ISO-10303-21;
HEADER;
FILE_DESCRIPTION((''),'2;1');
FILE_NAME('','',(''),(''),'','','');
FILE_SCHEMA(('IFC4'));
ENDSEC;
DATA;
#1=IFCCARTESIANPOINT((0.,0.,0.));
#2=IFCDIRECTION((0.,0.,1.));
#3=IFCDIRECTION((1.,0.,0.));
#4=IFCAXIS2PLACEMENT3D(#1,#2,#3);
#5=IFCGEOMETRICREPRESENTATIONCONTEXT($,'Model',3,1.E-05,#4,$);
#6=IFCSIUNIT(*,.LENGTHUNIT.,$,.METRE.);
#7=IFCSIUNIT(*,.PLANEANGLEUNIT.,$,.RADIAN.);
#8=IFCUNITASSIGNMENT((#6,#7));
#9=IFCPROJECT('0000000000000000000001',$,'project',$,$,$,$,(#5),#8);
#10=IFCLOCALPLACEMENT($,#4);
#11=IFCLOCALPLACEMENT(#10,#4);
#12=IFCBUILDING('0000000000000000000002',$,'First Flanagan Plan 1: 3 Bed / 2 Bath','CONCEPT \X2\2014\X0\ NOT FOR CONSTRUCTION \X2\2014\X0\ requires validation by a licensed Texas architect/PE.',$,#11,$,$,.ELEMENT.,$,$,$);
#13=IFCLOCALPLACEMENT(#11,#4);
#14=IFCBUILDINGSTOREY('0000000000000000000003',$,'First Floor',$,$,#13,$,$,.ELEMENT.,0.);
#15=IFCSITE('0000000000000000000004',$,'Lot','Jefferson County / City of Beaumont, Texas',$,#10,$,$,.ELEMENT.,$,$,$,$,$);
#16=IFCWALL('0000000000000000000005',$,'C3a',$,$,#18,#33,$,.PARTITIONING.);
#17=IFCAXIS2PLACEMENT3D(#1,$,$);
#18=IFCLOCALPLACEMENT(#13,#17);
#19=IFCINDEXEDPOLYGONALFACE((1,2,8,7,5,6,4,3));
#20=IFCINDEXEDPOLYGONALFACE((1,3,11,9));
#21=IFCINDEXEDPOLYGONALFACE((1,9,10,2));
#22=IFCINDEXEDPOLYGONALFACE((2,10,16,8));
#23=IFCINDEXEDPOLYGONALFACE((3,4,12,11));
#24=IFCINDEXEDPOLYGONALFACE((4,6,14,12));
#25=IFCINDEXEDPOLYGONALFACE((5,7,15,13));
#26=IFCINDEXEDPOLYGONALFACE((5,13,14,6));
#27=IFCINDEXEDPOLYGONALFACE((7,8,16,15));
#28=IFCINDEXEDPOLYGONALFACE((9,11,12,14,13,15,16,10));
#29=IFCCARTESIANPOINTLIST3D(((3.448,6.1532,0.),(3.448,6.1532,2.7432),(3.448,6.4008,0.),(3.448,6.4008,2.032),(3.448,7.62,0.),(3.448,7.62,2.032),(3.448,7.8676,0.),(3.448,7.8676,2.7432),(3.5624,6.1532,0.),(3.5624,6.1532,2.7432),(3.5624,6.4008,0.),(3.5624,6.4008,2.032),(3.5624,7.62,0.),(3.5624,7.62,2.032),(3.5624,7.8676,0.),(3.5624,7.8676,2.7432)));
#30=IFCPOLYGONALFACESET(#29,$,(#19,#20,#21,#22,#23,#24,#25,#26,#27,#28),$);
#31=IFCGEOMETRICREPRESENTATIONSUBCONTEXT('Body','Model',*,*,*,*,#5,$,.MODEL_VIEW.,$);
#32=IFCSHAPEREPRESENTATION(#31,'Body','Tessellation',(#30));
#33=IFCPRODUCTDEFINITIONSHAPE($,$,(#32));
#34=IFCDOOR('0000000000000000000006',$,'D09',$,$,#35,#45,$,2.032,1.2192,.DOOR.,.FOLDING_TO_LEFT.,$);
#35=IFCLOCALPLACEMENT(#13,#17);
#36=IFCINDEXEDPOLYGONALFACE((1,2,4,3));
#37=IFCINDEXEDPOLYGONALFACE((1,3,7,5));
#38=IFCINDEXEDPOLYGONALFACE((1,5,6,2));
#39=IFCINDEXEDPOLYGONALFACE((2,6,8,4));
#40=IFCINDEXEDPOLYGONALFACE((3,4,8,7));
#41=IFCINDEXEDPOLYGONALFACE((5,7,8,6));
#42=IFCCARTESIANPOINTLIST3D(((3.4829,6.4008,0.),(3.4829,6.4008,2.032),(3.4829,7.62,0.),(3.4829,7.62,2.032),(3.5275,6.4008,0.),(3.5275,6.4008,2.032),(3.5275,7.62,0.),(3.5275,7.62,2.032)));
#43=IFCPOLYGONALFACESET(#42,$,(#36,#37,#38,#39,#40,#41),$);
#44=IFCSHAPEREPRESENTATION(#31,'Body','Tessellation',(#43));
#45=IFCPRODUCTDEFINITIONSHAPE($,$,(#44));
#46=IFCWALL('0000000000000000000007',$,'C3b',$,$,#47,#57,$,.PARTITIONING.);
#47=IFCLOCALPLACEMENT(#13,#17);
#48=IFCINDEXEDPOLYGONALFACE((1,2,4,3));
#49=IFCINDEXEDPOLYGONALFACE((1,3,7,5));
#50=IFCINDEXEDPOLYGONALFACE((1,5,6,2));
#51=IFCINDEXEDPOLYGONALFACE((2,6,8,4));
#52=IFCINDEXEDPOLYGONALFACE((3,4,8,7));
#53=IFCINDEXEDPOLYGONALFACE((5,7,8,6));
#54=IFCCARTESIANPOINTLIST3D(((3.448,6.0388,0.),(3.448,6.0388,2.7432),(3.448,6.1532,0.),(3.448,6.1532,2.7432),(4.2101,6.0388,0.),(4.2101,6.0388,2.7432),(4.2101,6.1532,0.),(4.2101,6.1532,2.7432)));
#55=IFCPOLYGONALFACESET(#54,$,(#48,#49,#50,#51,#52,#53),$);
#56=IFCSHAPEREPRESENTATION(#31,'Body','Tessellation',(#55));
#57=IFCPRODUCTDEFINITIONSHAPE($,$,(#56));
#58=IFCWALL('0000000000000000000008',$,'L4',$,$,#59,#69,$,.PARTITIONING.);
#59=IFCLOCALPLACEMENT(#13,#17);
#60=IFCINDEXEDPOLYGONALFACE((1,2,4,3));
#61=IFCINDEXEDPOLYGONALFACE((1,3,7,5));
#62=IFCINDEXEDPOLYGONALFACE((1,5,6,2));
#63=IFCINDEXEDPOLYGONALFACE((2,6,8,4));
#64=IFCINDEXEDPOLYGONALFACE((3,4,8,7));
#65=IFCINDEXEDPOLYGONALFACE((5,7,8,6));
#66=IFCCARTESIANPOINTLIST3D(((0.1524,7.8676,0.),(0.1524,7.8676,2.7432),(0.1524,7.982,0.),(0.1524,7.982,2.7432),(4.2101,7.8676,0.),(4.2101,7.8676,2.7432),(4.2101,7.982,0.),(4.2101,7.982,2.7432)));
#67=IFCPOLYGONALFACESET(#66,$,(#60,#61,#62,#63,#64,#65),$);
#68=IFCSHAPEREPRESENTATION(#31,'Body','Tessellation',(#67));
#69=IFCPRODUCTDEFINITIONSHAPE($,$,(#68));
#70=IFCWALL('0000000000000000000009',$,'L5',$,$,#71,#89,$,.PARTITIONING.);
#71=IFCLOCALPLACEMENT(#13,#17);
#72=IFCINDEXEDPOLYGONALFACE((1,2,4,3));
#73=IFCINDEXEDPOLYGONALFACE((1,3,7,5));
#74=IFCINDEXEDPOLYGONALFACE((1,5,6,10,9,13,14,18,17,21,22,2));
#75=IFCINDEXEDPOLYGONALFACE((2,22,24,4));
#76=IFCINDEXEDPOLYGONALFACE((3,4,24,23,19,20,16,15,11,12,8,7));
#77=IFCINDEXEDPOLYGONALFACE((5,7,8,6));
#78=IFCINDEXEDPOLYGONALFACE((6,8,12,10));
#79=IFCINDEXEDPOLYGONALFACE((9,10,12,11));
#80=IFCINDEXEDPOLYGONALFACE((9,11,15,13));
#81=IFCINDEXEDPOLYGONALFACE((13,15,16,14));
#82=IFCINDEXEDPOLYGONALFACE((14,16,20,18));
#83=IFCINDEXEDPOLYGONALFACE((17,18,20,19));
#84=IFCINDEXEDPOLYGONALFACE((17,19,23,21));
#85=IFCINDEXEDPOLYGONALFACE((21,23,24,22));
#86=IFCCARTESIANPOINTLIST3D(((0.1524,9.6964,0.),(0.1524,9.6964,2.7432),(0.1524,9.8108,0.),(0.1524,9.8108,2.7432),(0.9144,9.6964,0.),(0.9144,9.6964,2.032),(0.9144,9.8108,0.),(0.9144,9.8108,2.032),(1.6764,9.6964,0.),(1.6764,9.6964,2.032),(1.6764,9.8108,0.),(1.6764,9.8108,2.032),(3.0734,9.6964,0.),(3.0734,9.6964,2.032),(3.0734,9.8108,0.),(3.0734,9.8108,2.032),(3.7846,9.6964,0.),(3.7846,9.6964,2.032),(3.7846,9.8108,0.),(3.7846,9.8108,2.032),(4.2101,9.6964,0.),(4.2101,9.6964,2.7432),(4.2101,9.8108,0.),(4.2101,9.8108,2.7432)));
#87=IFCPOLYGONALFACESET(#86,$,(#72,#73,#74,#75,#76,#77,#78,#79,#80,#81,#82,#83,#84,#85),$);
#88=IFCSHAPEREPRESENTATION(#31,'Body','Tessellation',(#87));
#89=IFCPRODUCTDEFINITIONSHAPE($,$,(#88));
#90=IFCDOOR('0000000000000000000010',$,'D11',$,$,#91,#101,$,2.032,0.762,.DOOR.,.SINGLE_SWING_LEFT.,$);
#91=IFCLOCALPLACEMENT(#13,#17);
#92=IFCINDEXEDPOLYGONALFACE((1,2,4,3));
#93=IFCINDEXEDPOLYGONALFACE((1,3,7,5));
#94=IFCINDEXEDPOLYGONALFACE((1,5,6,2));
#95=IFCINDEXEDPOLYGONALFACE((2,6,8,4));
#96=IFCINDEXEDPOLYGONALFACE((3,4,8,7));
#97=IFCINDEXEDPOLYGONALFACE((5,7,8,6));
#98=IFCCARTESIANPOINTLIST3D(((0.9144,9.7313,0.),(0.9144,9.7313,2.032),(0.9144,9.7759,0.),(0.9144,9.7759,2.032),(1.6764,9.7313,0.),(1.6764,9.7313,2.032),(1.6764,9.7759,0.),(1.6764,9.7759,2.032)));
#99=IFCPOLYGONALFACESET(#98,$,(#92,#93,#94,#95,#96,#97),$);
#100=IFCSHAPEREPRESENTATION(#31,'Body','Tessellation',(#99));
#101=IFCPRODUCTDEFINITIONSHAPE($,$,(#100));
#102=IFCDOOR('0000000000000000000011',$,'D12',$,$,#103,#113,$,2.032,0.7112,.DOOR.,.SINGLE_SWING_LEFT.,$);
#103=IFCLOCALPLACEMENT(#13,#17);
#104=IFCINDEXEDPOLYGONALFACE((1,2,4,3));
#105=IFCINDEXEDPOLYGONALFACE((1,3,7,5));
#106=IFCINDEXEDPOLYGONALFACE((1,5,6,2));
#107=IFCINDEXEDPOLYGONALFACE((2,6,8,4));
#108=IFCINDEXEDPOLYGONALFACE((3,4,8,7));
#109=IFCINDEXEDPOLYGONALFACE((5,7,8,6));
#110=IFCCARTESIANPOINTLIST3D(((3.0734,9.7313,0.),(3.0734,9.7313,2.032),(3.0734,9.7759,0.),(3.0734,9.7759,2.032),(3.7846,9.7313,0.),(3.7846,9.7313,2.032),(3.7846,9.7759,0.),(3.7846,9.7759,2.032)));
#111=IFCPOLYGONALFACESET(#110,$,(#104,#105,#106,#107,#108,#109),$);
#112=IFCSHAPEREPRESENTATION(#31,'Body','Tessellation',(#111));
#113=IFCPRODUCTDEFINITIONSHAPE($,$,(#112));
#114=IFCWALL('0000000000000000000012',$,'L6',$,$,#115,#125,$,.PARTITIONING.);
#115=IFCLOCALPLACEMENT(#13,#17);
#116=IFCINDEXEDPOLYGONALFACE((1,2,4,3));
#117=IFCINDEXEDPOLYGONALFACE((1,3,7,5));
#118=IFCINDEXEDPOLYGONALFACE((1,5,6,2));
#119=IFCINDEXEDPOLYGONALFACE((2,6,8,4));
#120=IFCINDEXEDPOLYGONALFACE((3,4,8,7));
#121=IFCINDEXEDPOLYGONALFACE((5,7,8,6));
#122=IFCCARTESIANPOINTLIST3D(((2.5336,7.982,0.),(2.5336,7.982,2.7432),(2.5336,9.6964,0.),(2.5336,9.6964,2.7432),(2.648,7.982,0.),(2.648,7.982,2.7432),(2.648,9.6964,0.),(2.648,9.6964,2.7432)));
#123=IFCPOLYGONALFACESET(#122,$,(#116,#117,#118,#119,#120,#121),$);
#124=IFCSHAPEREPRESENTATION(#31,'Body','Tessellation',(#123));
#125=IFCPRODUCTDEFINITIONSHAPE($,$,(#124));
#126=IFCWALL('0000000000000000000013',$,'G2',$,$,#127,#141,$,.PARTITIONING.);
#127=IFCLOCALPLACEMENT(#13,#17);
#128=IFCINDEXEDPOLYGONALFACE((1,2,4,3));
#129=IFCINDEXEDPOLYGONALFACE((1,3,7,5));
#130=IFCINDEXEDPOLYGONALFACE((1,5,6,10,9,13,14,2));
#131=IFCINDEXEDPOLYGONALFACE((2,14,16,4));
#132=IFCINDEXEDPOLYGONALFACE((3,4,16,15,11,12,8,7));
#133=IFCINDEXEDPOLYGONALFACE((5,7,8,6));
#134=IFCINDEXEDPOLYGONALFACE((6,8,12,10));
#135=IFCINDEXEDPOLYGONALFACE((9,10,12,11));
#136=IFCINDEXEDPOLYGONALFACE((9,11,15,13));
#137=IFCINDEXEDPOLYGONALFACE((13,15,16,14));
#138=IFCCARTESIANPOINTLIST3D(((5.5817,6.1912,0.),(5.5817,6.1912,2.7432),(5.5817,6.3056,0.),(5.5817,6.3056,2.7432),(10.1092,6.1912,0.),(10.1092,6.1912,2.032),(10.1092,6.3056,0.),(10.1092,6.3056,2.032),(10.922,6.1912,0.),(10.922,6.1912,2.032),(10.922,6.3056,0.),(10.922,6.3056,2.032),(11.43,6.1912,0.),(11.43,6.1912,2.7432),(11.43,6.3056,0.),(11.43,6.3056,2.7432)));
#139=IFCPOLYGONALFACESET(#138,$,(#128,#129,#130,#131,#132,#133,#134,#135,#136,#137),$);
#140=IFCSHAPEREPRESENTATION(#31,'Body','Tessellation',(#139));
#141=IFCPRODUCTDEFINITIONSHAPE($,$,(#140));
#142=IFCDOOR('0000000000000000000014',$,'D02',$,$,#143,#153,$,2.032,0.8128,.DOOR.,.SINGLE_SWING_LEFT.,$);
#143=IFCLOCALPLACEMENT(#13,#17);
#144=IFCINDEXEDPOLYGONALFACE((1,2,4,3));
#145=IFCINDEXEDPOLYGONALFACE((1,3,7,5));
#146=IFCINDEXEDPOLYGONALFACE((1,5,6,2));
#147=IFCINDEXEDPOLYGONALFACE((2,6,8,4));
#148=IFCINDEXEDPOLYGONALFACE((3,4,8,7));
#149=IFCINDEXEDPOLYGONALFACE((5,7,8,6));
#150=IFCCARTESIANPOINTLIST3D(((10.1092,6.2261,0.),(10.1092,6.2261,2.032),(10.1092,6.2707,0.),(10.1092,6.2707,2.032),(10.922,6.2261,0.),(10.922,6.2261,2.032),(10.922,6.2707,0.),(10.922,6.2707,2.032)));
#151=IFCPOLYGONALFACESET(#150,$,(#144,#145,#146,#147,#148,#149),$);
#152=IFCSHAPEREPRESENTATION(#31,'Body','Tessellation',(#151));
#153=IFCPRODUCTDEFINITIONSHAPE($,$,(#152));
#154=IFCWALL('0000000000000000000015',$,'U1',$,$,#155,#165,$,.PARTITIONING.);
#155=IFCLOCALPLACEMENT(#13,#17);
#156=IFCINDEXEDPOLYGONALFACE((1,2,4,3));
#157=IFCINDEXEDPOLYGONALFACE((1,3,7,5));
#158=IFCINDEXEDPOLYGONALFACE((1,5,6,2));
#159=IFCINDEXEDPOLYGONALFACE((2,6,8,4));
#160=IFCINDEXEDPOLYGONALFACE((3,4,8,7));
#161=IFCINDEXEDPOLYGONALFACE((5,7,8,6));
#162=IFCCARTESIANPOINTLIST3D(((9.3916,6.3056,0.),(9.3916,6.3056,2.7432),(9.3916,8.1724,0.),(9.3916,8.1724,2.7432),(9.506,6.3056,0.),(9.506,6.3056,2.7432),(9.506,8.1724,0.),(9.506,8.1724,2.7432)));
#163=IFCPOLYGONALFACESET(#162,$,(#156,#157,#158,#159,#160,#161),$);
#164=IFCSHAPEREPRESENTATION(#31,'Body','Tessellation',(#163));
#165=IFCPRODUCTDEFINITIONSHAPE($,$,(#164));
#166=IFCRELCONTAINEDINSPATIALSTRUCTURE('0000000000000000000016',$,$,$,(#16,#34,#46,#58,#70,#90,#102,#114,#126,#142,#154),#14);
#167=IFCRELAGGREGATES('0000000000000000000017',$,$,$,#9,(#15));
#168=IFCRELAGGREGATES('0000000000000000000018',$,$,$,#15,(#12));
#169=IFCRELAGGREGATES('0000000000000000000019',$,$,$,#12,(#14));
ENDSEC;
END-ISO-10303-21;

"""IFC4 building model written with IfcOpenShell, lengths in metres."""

from ifc_helpers import new_model, si_unit, frame, frame_2d, origin_with_axes, place, context, subcontext, project, spatial, rectangle, extrude, element, fill, save


model = new_model("IFC4")

# Units and contexts
model_context = context("Model", 3, precision=1e-05, world=origin_with_axes())
body_context = subcontext(model_context, "Body", "Model", "MODEL_VIEW")
ifc_project = project(units=[si_unit("LENGTHUNIT", "METRE"), si_unit("PLANEANGLEUNIT", "RADIAN")], contexts=[model_context])

# Site, building, storey
site_placement = place(None, origin_with_axes())
site = spatial("IfcSite", under=ifc_project, at=site_placement, Name="Lot", Description="Jefferson County / City of Beaumont, Texas", CompositionType="ELEMENT")
building_placement = place(site_placement, origin_with_axes())
building = spatial("IfcBuilding", under=site, at=building_placement, Name="First Flanagan Plan 1: 3 Bed / 2 Bath", Description="CONCEPT — NOT FOR CONSTRUCTION — requires validation by a licensed Texas architect/PE.", CompositionType="ELEMENT")
storey_placement = place(building_placement, origin_with_axes())
storey = spatial("IfcBuildingStorey", under=building, at=storey_placement, Name="First Floor", CompositionType="ELEMENT", Elevation=0.0)

# Wall, opening, door
wall_1_placement = place(storey_placement, frame((3.5052, 6.1532, 0.0), z_axis=(0.0, 0.0, 1.0), x_axis=(0.0, 1.0, 0.0)))
wall_1 = element("IfcWall", 1, at=wall_1_placement, inside=storey, Name="C3a", PredefinedType="PARTITIONING", context=body_context, shape_type="SweptSolid", body=[
    extrude(rectangle(XDim=1.7145, YDim=0.1143, at=frame_2d((0.8573, 0.0), x_axis=(1.0, 0.0))), origin_with_axes(), (0.0, 0.0, 1.0), 2.7432),
])
opening_1_placement = place(wall_1_placement, frame((0.2477, 0.0, 0.0), z_axis=(0.0, 0.0, 1.0), x_axis=(1.0, 0.0, 0.0)))
opening_1 = element("IfcOpeningElement", 2, at=opening_1_placement, cuts=wall_1, PredefinedType="OPENING", context=body_context, shape_type="SweptSolid", body=[
    extrude(rectangle(XDim=1.2192, YDim=0.1448, at=frame_2d((0.6096, 0.0), x_axis=(1.0, 0.0))), origin_with_axes(), (0.0, 0.0, 1.0), 2.032),
])
door_1_placement = place(opening_1_placement, origin_with_axes())
door_1 = element("IfcDoor", 3, at=door_1_placement, inside=storey, Name="D09", OperationType="FOLDING_TO_LEFT", OverallHeight=2.032, OverallWidth=1.2192, PredefinedType="DOOR", context=body_context, shape_type="SweptSolid", body=[
    extrude(rectangle(XDim=1.2192, YDim=0.0445, at=frame_2d((0.6096, 0.0), x_axis=(1.0, 0.0))), origin_with_axes(), (0.0, 0.0, 1.0), 2.032),
])
fill(opening_1, door_1)

# Walls
wall_2_placement = place(storey_placement, frame((3.4481, 6.096, 0.0), z_axis=(0.0, 0.0, 1.0), x_axis=(1.0, 0.0, 0.0)))
element("IfcWall", 4, at=wall_2_placement, inside=storey, Name="C3b", PredefinedType="PARTITIONING", context=body_context, shape_type="SweptSolid", body=[
    extrude(rectangle(XDim=0.762, YDim=0.1143, at=frame_2d((0.381, 0.0), x_axis=(1.0, 0.0))), origin_with_axes(), (0.0, 0.0, 1.0), 2.7432),
])
wall_3_placement = place(storey_placement, frame((0.1524, 7.9248, 0.0), z_axis=(0.0, 0.0, 1.0), x_axis=(1.0, 0.0, 0.0)))
element("IfcWall", 5, at=wall_3_placement, inside=storey, Name="L4", PredefinedType="PARTITIONING", context=body_context, shape_type="SweptSolid", body=[
    extrude(rectangle(XDim=4.0577, YDim=0.1143, at=frame_2d((2.0288, 0.0), x_axis=(1.0, 0.0))), origin_with_axes(), (0.0, 0.0, 1.0), 2.7432),
])

# Wall, openings, doors
wall_4_placement = place(storey_placement, frame((0.1524, 9.7536, 0.0), z_axis=(0.0, 0.0, 1.0), x_axis=(1.0, 0.0, 0.0)))
wall_4 = element("IfcWall", 6, at=wall_4_placement, inside=storey, Name="L5", PredefinedType="PARTITIONING", context=body_context, shape_type="SweptSolid", body=[
    extrude(rectangle(XDim=4.0577, YDim=0.1143, at=frame_2d((2.0288, 0.0), x_axis=(1.0, 0.0))), origin_with_axes(), (0.0, 0.0, 1.0), 2.7432),
])
opening_2_placement = place(wall_4_placement, frame((0.762, 0.0, 0.0), z_axis=(0.0, 0.0, 1.0), x_axis=(1.0, 0.0, 0.0)))
opening_2 = element("IfcOpeningElement", 7, at=opening_2_placement, cuts=wall_4, PredefinedType="OPENING", context=body_context, shape_type="SweptSolid", body=[
    extrude(rectangle(XDim=0.762, YDim=0.1448, at=frame_2d((0.381, 0.0), x_axis=(1.0, 0.0))), origin_with_axes(), (0.0, 0.0, 1.0), 2.032),
])
opening_3_placement = place(wall_4_placement, frame((2.921, 0.0, 0.0), z_axis=(0.0, 0.0, 1.0), x_axis=(1.0, 0.0, 0.0)))
opening_3 = element("IfcOpeningElement", 8, at=opening_3_placement, cuts=wall_4, PredefinedType="OPENING", context=body_context, shape_type="SweptSolid", body=[
    extrude(rectangle(XDim=0.7112, YDim=0.1448, at=frame_2d((0.3556, 0.0), x_axis=(1.0, 0.0))), origin_with_axes(), (0.0, 0.0, 1.0), 2.032),
])
door_2_placement = place(opening_2_placement, origin_with_axes())
door_2 = element("IfcDoor", 9, at=door_2_placement, inside=storey, Name="D11", OperationType="SINGLE_SWING_LEFT", OverallHeight=2.032, OverallWidth=0.762, PredefinedType="DOOR", context=body_context, shape_type="SweptSolid", body=[
    extrude(rectangle(XDim=0.762, YDim=0.0445, at=frame_2d((0.381, 0.0), x_axis=(1.0, 0.0))), origin_with_axes(), (0.0, 0.0, 1.0), 2.032),
])
fill(opening_2, door_2)
door_3_placement = place(opening_3_placement, origin_with_axes())
door_3 = element("IfcDoor", 10, at=door_3_placement, inside=storey, Name="D12", OperationType="SINGLE_SWING_LEFT", OverallHeight=2.032, OverallWidth=0.7112, PredefinedType="DOOR", context=body_context, shape_type="SweptSolid", body=[
    extrude(rectangle(XDim=0.7112, YDim=0.0445, at=frame_2d((0.3556, 0.0), x_axis=(1.0, 0.0))), origin_with_axes(), (0.0, 0.0, 1.0), 2.032),
])
fill(opening_3, door_3)

# Wall
wall_5_placement = place(storey_placement, frame((2.5908, 7.982, 0.0), z_axis=(0.0, 0.0, 1.0), x_axis=(0.0, 1.0, 0.0)))
element("IfcWall", 11, at=wall_5_placement, inside=storey, Name="L6", PredefinedType="PARTITIONING", context=body_context, shape_type="SweptSolid", body=[
    extrude(rectangle(XDim=1.7145, YDim=0.1143, at=frame_2d((0.8573, 0.0), x_axis=(1.0, 0.0))), origin_with_axes(), (0.0, 0.0, 1.0), 2.7432),
])

# Wall, opening, door
wall_6_placement = place(storey_placement, frame((5.5817, 6.2484, 0.0), z_axis=(0.0, 0.0, 1.0), x_axis=(1.0, 0.0, 0.0)))
wall_6 = element("IfcWall", 12, at=wall_6_placement, inside=storey, Name="G2", PredefinedType="PARTITIONING", context=body_context, shape_type="SweptSolid", body=[
    extrude(rectangle(XDim=5.8483, YDim=0.1143, at=frame_2d((2.9242, 0.0), x_axis=(1.0, 0.0))), origin_with_axes(), (0.0, 0.0, 1.0), 2.7432),
])
opening_4_placement = place(wall_6_placement, frame((4.5275, 0.0, 0.0), z_axis=(0.0, 0.0, 1.0), x_axis=(1.0, 0.0, 0.0)))
opening_4 = element("IfcOpeningElement", 13, at=opening_4_placement, cuts=wall_6, PredefinedType="OPENING", context=body_context, shape_type="SweptSolid", body=[
    extrude(rectangle(XDim=0.8128, YDim=0.1448, at=frame_2d((0.4064, 0.0), x_axis=(1.0, 0.0))), origin_with_axes(), (0.0, 0.0, 1.0), 2.032),
])
door_4_placement = place(opening_4_placement, origin_with_axes())
door_4 = element("IfcDoor", 14, at=door_4_placement, inside=storey, Name="D02", OperationType="SINGLE_SWING_LEFT", OverallHeight=2.032, OverallWidth=0.8128, PredefinedType="DOOR", context=body_context, shape_type="SweptSolid", body=[
    extrude(rectangle(XDim=0.8128, YDim=0.0445, at=frame_2d((0.4064, 0.0), x_axis=(1.0, 0.0))), origin_with_axes(), (0.0, 0.0, 1.0), 2.032),
])
fill(opening_4, door_4)

# Wall
wall_7_placement = place(storey_placement, frame((9.4488, 6.3056, 0.0), z_axis=(0.0, 0.0, 1.0), x_axis=(0.0, 1.0, 0.0)))
element("IfcWall", 15, at=wall_7_placement, inside=storey, Name="U1", PredefinedType="PARTITIONING", context=body_context, shape_type="SweptSolid", body=[
    extrude(rectangle(XDim=1.8669, YDim=0.1143, at=frame_2d((0.9335, 0.0), x_axis=(1.0, 0.0))), origin_with_axes(), (0.0, 0.0, 1.0), 2.7432),
])

save(model, "model.ifc")
